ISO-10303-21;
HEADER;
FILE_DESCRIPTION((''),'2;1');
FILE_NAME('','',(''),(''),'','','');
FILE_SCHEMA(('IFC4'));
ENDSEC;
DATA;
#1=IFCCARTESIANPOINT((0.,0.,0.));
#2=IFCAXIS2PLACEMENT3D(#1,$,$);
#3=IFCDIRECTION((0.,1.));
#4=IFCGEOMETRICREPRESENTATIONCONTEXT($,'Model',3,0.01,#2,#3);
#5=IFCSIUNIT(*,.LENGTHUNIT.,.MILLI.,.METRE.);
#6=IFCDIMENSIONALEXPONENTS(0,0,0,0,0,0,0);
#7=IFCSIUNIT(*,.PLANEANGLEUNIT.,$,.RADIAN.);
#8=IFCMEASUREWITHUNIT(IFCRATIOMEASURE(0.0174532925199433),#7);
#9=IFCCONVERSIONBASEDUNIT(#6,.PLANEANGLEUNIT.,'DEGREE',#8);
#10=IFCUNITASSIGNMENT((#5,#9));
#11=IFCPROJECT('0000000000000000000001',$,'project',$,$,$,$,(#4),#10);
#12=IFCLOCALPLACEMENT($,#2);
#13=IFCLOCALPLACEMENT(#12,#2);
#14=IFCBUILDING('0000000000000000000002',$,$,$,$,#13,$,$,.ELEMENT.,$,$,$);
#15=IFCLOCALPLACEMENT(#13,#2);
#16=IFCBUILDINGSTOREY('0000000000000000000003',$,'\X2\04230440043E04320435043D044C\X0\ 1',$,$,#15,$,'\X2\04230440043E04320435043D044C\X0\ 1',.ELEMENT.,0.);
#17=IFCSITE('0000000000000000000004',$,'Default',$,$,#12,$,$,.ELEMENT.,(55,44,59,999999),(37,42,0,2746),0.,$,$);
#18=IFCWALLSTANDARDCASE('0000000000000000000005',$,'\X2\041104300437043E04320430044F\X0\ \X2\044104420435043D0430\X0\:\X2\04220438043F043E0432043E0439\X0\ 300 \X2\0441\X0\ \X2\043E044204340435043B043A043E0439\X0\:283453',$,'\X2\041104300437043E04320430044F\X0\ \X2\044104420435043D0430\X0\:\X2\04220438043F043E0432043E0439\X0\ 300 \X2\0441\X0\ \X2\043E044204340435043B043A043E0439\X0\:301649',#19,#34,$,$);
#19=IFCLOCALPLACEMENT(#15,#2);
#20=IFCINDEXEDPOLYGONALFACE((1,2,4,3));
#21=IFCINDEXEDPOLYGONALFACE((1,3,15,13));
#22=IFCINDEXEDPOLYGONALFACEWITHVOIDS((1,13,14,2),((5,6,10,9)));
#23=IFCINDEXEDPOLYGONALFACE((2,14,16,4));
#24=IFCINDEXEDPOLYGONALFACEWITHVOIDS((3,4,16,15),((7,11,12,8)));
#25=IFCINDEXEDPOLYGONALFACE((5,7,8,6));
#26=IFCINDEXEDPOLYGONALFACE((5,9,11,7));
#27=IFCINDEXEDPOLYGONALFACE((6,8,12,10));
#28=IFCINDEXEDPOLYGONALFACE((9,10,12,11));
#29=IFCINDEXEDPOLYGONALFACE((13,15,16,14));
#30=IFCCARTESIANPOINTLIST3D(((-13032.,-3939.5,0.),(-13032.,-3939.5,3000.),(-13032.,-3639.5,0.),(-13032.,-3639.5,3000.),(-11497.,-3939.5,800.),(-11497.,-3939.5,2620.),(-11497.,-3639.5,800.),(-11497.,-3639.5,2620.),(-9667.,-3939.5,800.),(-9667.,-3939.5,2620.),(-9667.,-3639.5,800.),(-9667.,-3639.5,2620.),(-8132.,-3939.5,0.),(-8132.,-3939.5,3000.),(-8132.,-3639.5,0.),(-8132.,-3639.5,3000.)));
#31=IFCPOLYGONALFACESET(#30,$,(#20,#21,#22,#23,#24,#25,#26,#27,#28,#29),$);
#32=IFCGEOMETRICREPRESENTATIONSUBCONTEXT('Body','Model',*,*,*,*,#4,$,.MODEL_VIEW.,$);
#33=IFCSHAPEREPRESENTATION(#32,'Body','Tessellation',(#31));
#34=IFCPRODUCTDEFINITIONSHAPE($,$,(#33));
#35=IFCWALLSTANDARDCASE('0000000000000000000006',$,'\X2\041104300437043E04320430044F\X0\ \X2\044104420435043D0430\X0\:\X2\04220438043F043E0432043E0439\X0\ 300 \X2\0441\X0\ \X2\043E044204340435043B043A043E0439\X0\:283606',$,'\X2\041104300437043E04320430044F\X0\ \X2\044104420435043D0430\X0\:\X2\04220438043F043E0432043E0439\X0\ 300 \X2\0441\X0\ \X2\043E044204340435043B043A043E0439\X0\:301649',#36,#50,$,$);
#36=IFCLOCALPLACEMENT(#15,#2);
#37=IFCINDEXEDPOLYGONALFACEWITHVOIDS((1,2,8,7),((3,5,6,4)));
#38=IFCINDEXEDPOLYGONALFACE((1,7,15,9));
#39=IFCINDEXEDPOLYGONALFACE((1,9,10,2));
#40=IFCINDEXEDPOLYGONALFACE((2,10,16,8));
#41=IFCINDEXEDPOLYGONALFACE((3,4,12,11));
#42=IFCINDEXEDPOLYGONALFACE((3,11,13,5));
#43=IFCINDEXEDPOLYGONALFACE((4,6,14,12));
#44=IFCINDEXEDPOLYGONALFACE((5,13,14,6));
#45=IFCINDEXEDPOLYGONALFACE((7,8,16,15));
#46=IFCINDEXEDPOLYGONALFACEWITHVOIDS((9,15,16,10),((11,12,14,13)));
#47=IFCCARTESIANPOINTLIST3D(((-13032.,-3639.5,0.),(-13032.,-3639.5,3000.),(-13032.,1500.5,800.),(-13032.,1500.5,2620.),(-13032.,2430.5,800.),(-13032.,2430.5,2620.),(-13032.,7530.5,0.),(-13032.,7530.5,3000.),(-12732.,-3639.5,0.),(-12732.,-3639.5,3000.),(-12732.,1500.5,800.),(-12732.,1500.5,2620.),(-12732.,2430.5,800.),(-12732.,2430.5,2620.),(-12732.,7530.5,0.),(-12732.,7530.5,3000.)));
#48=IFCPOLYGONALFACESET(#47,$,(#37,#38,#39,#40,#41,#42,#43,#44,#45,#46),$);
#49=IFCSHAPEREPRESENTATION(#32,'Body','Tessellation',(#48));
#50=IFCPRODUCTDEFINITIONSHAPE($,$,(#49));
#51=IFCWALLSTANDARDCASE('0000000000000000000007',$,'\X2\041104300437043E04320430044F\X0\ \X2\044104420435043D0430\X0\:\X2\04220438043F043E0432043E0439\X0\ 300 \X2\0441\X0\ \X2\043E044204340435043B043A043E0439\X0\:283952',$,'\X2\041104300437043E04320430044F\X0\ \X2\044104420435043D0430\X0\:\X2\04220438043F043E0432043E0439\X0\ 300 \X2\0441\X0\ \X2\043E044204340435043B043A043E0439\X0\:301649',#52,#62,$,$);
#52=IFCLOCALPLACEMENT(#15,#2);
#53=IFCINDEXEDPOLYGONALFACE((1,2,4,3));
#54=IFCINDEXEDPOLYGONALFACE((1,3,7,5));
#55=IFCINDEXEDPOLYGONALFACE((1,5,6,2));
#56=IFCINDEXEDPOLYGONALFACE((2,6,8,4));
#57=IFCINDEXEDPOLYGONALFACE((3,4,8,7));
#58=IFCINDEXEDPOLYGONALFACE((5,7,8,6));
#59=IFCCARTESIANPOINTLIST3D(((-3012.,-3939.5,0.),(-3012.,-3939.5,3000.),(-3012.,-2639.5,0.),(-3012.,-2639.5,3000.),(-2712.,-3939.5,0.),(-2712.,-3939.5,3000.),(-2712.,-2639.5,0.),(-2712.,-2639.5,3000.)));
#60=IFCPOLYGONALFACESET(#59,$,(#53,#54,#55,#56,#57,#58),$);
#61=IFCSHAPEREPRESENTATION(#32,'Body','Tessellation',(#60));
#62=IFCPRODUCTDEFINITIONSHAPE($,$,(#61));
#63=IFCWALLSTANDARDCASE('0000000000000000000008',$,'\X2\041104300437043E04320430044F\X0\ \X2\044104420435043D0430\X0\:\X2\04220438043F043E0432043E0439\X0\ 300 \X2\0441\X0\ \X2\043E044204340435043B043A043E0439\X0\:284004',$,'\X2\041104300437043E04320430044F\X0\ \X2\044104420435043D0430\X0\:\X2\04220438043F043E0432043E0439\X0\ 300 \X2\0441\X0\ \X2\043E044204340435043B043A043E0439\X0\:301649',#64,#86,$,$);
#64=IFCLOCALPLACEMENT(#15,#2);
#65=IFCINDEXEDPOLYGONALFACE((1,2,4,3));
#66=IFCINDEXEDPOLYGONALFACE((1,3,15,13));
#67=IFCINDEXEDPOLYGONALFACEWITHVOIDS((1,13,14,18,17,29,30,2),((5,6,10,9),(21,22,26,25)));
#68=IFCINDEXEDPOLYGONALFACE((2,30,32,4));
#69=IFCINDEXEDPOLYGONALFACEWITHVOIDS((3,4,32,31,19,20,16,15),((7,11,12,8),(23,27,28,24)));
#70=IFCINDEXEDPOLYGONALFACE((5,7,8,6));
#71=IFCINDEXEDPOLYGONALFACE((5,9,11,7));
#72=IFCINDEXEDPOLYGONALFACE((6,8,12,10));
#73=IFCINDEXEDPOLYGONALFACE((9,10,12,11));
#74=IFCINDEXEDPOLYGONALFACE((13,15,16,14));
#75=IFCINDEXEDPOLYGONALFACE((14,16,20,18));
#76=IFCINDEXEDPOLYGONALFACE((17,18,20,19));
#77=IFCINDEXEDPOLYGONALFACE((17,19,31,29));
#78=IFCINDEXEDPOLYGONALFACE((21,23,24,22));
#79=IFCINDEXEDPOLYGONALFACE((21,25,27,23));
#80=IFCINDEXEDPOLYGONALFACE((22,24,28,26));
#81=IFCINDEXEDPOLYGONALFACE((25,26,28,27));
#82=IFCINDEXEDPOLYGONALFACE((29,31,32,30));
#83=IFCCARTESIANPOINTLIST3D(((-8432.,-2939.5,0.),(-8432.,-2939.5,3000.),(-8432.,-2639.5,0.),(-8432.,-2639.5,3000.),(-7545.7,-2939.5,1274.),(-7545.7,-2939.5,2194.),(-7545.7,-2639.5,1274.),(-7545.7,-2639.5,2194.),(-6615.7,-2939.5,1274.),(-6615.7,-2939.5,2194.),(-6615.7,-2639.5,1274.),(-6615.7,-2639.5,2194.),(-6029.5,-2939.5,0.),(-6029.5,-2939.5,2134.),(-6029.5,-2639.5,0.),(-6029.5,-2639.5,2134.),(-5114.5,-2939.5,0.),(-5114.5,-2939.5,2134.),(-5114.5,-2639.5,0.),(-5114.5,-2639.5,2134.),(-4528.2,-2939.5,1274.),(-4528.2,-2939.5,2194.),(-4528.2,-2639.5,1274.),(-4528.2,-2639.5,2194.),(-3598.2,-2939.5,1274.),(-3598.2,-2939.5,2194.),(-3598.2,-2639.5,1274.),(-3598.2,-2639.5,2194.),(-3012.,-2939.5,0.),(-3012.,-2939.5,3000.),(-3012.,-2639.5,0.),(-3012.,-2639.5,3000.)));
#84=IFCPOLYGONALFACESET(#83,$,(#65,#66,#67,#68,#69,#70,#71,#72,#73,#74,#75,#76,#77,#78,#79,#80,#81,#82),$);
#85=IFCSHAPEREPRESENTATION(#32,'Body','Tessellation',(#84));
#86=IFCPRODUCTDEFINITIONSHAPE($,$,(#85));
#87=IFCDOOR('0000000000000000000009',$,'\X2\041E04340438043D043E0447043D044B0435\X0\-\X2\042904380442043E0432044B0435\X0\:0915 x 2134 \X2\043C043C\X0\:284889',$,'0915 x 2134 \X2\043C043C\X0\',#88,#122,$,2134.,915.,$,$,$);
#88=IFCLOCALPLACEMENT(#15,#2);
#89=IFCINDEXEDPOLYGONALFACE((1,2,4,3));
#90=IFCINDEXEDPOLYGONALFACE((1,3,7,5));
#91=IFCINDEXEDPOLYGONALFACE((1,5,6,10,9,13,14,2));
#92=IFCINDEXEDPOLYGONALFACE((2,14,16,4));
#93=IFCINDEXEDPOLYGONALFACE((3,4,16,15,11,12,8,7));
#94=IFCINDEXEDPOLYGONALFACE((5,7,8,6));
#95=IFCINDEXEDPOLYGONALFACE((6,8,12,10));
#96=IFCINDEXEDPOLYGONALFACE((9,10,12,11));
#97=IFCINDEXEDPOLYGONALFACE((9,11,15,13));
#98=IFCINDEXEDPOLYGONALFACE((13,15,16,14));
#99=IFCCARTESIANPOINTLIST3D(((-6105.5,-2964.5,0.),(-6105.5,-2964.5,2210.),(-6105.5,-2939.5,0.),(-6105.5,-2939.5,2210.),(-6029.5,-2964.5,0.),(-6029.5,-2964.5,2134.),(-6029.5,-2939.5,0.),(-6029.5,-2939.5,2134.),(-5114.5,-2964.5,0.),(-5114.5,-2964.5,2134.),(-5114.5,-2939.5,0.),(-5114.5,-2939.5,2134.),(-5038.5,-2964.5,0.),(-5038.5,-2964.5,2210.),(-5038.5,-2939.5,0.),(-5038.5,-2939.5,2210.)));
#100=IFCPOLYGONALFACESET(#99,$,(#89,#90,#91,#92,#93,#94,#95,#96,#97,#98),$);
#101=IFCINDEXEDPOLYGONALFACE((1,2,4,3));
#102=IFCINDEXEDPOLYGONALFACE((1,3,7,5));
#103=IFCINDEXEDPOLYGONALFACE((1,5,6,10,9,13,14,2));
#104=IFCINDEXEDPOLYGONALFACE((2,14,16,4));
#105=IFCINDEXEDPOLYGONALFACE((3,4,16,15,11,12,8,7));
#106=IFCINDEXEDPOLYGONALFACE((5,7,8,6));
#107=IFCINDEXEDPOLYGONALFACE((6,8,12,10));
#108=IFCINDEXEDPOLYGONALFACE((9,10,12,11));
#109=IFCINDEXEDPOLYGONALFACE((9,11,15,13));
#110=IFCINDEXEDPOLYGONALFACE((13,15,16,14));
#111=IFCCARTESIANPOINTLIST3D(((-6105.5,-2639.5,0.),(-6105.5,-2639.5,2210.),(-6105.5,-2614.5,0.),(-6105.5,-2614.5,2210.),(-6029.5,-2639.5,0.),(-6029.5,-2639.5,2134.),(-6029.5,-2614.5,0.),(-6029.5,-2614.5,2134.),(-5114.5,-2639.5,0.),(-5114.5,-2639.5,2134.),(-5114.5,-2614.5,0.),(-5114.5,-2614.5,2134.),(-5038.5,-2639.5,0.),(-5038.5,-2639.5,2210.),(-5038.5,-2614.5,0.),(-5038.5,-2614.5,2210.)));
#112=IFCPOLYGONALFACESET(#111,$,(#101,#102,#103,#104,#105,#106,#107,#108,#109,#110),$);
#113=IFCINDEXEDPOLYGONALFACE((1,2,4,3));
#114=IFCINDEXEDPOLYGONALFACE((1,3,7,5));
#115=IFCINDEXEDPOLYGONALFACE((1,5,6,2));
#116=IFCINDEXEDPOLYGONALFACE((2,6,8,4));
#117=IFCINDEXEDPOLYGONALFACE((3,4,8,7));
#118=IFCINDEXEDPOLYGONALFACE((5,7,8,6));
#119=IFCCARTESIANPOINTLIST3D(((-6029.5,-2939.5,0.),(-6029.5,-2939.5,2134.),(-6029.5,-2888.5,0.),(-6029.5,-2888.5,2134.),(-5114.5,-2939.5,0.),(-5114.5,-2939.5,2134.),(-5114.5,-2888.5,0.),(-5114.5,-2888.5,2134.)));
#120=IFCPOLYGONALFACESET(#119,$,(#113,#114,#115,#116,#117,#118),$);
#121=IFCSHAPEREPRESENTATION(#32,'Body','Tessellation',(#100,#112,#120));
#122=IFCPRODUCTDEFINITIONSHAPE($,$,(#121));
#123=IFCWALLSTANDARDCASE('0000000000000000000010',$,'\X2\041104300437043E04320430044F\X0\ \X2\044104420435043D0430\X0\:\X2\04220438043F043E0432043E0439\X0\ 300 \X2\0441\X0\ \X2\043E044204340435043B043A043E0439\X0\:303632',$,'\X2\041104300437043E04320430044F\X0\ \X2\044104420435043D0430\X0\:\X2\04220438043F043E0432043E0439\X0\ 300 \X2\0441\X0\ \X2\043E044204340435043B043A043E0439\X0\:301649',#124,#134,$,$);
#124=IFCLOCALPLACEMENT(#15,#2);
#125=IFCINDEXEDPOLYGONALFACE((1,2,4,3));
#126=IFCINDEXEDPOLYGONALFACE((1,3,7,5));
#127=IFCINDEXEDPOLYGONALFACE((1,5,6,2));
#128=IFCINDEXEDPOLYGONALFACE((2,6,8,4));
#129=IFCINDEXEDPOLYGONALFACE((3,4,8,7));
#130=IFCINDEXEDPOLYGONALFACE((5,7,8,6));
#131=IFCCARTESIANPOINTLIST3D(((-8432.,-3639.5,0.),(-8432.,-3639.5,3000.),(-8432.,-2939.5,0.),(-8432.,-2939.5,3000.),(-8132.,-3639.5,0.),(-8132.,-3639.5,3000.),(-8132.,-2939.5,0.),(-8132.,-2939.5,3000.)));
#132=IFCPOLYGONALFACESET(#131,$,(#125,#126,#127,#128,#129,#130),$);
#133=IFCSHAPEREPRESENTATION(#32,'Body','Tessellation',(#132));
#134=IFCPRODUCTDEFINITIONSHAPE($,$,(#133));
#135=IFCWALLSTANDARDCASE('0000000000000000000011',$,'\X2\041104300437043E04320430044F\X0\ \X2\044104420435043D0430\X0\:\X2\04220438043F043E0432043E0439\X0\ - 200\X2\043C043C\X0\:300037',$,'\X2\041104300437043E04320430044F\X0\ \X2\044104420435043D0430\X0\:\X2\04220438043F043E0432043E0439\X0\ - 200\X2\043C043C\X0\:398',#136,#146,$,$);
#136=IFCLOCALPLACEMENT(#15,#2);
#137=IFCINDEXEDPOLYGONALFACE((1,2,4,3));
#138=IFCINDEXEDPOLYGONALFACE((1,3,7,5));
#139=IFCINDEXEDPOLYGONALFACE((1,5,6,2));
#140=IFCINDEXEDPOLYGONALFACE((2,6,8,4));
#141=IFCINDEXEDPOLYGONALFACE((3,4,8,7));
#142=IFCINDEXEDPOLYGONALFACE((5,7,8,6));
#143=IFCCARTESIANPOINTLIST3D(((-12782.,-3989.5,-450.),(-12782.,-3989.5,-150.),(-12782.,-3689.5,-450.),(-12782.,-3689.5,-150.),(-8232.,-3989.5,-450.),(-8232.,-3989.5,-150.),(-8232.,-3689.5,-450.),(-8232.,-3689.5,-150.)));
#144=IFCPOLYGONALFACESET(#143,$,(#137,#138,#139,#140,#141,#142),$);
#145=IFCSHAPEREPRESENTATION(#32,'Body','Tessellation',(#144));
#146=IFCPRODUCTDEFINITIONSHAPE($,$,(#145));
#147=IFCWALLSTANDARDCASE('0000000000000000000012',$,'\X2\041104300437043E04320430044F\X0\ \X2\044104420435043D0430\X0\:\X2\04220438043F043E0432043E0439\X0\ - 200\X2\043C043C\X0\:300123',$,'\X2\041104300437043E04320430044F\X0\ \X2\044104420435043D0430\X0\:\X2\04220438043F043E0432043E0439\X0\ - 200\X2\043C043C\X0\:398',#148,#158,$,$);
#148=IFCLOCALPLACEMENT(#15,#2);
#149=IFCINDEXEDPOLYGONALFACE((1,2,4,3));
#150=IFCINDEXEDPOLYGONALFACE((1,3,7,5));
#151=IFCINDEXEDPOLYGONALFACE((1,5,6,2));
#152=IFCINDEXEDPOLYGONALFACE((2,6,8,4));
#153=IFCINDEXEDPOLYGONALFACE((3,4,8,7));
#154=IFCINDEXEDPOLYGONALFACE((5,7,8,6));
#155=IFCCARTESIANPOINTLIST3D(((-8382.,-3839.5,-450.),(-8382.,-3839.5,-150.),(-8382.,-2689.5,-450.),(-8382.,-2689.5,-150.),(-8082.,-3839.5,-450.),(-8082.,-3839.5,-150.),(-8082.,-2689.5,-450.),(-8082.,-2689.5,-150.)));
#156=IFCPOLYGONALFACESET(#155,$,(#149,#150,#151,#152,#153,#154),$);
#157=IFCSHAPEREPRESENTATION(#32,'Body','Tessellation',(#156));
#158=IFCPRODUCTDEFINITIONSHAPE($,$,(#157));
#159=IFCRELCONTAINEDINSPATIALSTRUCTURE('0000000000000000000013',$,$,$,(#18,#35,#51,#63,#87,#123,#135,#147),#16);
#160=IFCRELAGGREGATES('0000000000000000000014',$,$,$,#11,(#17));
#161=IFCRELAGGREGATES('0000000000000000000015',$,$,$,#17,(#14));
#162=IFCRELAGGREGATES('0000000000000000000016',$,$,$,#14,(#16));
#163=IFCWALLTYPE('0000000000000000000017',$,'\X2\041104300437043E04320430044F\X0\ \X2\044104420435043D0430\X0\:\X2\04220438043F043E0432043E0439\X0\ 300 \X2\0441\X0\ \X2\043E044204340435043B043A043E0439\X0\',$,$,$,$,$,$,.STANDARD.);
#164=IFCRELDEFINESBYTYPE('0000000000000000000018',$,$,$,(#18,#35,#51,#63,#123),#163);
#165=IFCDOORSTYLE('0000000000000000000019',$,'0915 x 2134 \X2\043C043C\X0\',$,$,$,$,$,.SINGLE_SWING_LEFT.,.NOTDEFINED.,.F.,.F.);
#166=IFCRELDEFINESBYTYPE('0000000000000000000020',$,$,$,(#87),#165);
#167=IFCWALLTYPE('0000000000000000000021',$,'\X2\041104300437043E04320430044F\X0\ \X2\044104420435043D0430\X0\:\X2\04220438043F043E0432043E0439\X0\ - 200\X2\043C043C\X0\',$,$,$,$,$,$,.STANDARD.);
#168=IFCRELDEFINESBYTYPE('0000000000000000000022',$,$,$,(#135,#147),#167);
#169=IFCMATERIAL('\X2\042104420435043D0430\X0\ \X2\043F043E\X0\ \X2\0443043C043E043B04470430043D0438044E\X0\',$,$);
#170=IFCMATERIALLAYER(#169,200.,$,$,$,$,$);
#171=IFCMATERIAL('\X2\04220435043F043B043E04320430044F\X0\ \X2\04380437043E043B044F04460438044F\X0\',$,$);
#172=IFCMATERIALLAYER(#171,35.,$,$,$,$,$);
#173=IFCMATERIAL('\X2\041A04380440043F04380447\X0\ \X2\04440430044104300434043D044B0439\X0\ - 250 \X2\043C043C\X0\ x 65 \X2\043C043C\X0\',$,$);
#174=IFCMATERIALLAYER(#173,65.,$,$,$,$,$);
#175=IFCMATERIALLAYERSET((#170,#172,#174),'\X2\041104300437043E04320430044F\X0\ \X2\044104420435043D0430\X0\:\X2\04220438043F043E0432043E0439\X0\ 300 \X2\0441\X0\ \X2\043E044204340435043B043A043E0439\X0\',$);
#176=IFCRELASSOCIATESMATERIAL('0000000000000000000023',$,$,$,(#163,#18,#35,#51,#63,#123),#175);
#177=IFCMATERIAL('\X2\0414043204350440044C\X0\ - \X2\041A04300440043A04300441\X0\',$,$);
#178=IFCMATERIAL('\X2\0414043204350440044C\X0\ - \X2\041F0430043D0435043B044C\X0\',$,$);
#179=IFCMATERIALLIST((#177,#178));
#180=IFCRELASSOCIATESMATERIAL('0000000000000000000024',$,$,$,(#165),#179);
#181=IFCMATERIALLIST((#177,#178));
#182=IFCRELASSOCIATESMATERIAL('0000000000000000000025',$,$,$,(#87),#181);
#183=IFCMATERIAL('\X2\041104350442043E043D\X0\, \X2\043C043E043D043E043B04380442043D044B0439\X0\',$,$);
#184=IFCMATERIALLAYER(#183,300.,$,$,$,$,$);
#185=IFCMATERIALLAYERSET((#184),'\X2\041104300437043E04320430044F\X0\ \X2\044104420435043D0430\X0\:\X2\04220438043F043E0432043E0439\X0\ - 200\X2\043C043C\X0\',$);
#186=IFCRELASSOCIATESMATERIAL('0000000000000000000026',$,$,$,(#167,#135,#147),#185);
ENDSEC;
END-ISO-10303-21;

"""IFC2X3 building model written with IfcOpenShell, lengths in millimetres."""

from ifc_helpers import new_model, entity, si_unit, converted_unit, direction, frame, frame_2d, origin, origin_2d_with_axis, place, context, subcontext, project, spatial, polyline, rectangle, outline, extrude, clip, halfspace, source, transform, mapped, material, material_list, layer, layer_set, layer_usage, type_object, type_shapes, element, fill, save


model = new_model("IFC2X3")

# Units and contexts
model_context = context("Model", 3, precision=0.01, world=origin(), true_north=direction((0.0, 1.0)))
body_context = subcontext(model_context, "Body", "Model", "MODEL_VIEW")
ifc_project = project(units=[si_unit("LENGTHUNIT", "METRE", prefix="MILLI"), converted_unit("PLANEANGLEUNIT", "DEGREE", entity("IfcRatioMeasure", 0.0174532925199433), si_unit("PLANEANGLEUNIT", "RADIAN"), dimensions=[0, 0, 0, 0, 0, 0, 0])], contexts=[model_context])

# Site, building, storey
site_placement = place(None, origin())
site = spatial("IfcSite", under=ifc_project, at=site_placement, Name="Default", CompositionType="ELEMENT", RefLatitude=(55, 44, 59, 999999), RefLongitude=(37, 42, 0, 2746), RefElevation=0.0)
building_placement = place(site_placement, origin())
building = spatial("IfcBuilding", under=site, at=building_placement, CompositionType="ELEMENT")
storey_placement = place(building_placement, origin())
storey = spatial("IfcBuildingStorey", under=building, at=storey_placement, Name="Уровень 1", LongName="Уровень 1", CompositionType="ELEMENT", Elevation=0.0)

# Walls, openings
ifc_material_1 = material(Name="Стена по умолчанию")
ifc_layer_1 = layer(ifc_material_1, 200.0)
ifc_material_2 = material(Name="Тепловая изоляция")
ifc_layer_2 = layer(ifc_material_2, 35.0)
ifc_material_3 = material(Name="Кирпич фасадный - 250 мм x 65 мм")
ifc_layer_3 = layer(ifc_material_3, 65.0)
ifc_layer_set_1 = layer_set([ifc_layer_1, ifc_layer_2, ifc_layer_3], Name="Базовая стена:Типовой 300 с отделкой")
ifc_layer_usage_1 = layer_usage(ifc_layer_set_1, "AXIS2", "NEGATIVE", 150.0)
wall_type_1 = type_object("IfcWallType", Name="Базовая стена:Типовой 300 с отделкой", PredefinedType="STANDARD", material=ifc_layer_set_1)
wall_1_placement = place(storey_placement, frame((-13032.0, -3789.5, 0.0)))
wall_1 = element("IfcWallStandardCase", 1, at=wall_1_placement, inside=storey, type_object=wall_type_1, material=ifc_layer_usage_1, Name="Базовая стена:Типовой 300 с отделкой:283453", ObjectType="Базовая стена:Типовой 300 с отделкой:301649", context=body_context, shape_type="Clipping", body=[
    clip(extrude(rectangle(XDim=4900.0, YDim=300.0, at=frame_2d((2450.0, 0.0), x_axis=(-1.0, 0.0))), origin(), (0.0, 0.0, 1.0), 3000.0), halfspace(origin(), True)),
])
opening_1_placement = place(wall_1_placement, frame((3365.0, 150.0, 800.0)))
element("IfcOpeningElement", 2, at=opening_1_placement, cuts=wall_1, ObjectType="Opening", context=body_context, shape_type="SweptSolid", body=[
    extrude(rectangle(XDim=1820.0, YDim=1830.0, at=frame_2d((910.0, 915.0), x_axis=(1.0, 0.0))), frame((0.0, 0.0, 0.0), z_axis=(0.0, -1.0, 0.0), x_axis=(0.0, 0.0, 1.0)), (0.0, 0.0, 1.0), 300.0),
])
ifc_layer_usage_2 = layer_usage(ifc_layer_set_1, "AXIS2", "NEGATIVE", 150.0)
wall_2_placement = place(storey_placement, frame((-12882.0, 7530.5, 0.0), z_axis=(0.0, 0.0, 1.0), x_axis=(0.0, -1.0, 0.0)))
wall_2 = element("IfcWallStandardCase", 3, at=wall_2_placement, inside=storey, type_object=wall_type_1, material=ifc_layer_usage_2, Name="Базовая стена:Типовой 300 с отделкой:283606", ObjectType="Базовая стена:Типовой 300 с отделкой:301649", context=body_context, shape_type="Clipping", body=[
    clip(extrude(rectangle(XDim=11170.0, YDim=300.0, at=frame_2d((5585.0, 0.0), x_axis=(-1.0, 0.0))), origin(), (0.0, 0.0, 1.0), 3000.0), halfspace(origin(), True)),
])
opening_2_placement = place(wall_2_placement, frame((6030.0, 150.0, 800.0)))
element("IfcOpeningElement", 4, at=opening_2_placement, cuts=wall_2, ObjectType="Opening", context=body_context, shape_type="SweptSolid", body=[
    extrude(rectangle(XDim=1820.0, YDim=930.0, at=frame_2d((910.0, 465.0), x_axis=(1.0, 0.0))), frame((0.0, 0.0, 0.0), z_axis=(0.0, -1.0, 0.0), x_axis=(0.0, 0.0, 1.0)), (0.0, 0.0, 1.0), 300.0),
])

# Wall
ifc_layer_usage_3 = layer_usage(ifc_layer_set_1, "AXIS2", "NEGATIVE", 150.0)
wall_3_placement = place(storey_placement, frame((-2862.0, -2639.5, 0.0), z_axis=(0.0, 0.0, 1.0), x_axis=(0.0, -1.0, 0.0)))
element("IfcWallStandardCase", 5, at=wall_3_placement, inside=storey, type_object=wall_type_1, material=ifc_layer_usage_3, Name="Базовая стена:Типовой 300 с отделкой:283952", ObjectType="Базовая стена:Типовой 300 с отделкой:301649", context=body_context, shape_type="Clipping", body=[
    clip(extrude(rectangle(XDim=1300.0, YDim=300.0, at=frame_2d((650.0, 0.0), x_axis=(-1.0, 0.0))), origin(), (0.0, 0.0, 1.0), 3000.0), halfspace(origin(), True)),
])

# Wall, openings, door
ifc_layer_usage_4 = layer_usage(ifc_layer_set_1, "AXIS2", "NEGATIVE", 150.0)
wall_4_placement = place(storey_placement, frame((-8432.0, -2789.5, 0.0)))
wall_4 = element("IfcWallStandardCase", 6, at=wall_4_placement, inside=storey, type_object=wall_type_1, material=ifc_layer_usage_4, Name="Базовая стена:Типовой 300 с отделкой:284004", ObjectType="Базовая стена:Типовой 300 с отделкой:301649", context=body_context, shape_type="Clipping", body=[
    clip(extrude(rectangle(XDim=5420.0, YDim=300.0, at=frame_2d((2710.0, 0.0), x_axis=(-1.0, 0.0))), origin(), (0.0, 0.0, 1.0), 3000.0), halfspace(origin(), True)),
])
opening_3_placement = place(wall_4_placement, frame((3317.5, 150.0, 0.0)))
opening_3 = element("IfcOpeningElement", 7, at=opening_3_placement, cuts=wall_4, ObjectType="Opening", context=body_context, shape_type="SweptSolid", body=[
    extrude(rectangle(XDim=915.0, YDim=2134.0, at=frame_2d((1067.0, 457.5), x_axis=(0.0, -1.0))), frame((0.0, 0.0, 0.0), z_axis=(0.0, -1.0, 0.0), x_axis=(0.0, 0.0, 1.0)), (0.0, 0.0, 1.0), 300.0),
])
opening_4_placement = place(wall_4_placement, frame((4833.8, 150.0, 1274.0)))
element("IfcOpeningElement", 8, at=opening_4_placement, cuts=wall_4, ObjectType="Opening", context=body_context, shape_type="SweptSolid", body=[
    extrude(rectangle(XDim=920.0, YDim=930.0, at=frame_2d((460.0, 465.0), x_axis=(1.0, 0.0))), frame((0.0, 0.0, 0.0), z_axis=(0.0, -1.0, 0.0), x_axis=(0.0, 0.0, 1.0)), (0.0, 0.0, 1.0), 300.0),
])
opening_5_placement = place(wall_4_placement, frame((1816.2, 150.0, 1274.0)))
element("IfcOpeningElement", 9, at=opening_5_placement, cuts=wall_4, ObjectType="Opening", context=body_context, shape_type="SweptSolid", body=[
    extrude(rectangle(XDim=920.0, YDim=930.0, at=frame_2d((460.0, 465.0), x_axis=(1.0, 0.0))), frame((0.0, 0.0, 0.0), z_axis=(0.0, -1.0, 0.0), x_axis=(0.0, 0.0, 1.0)), (0.0, 0.0, 1.0), 300.0),
])
ifc_material_4 = material(Name="Дверь - Каркас")
ifc_material_5 = material(Name="Дверь - Панель")
ifc_material_list_1 = material_list([ifc_material_4, ifc_material_5])
ifc_material_list_2 = material_list([ifc_material_4, ifc_material_5])
door_style = type_object("IfcDoorStyle", Name="0915 x 2134 мм", ConstructionType="NOTDEFINED", OperationType="SINGLE_SWING_LEFT", ParameterTakesPrecedence=False, Sizeable=False, material=ifc_material_list_2)
shared_shape = source(origin(), body_context, "Body", "SweptSolid", [
    extrude(outline(polyline([(-533.5, -1124.0), (533.5, -1124.0), (533.5, 1086.0), (457.5, 1086.0), (457.5, -1048.0), (-457.5, -1048.0), (-457.5, 1086.0), (-533.5, 1086.0), (-533.5, -1124.0)])), frame((457.5, 325.0, 1086.0), z_axis=(0.0, -1.0, 0.0), x_axis=(-1.0, 0.0, 0.0)), (0.0, 0.0, 1.0), 25.0),
    extrude(outline(polyline([(-1124.0, -533.5), (1086.0, -533.5), (1086.0, -457.5), (-1048.0, -457.5), (-1048.0, 457.5), (1086.0, 457.5), (1086.0, 533.5), (-1124.0, 533.5), (-1124.0, -533.5)])), frame((457.5, 0.0, 1086.0), z_axis=(0.0, -1.0, 0.0), x_axis=(0.0, 0.0, -1.0)), (0.0, 0.0, 1.0), 25.0),
    extrude(rectangle(XDim=915.0, YDim=51.0, at=origin_2d_with_axis()), frame((457.5, 274.5, 0.0)), (0.0, 0.0, 1.0), 2134.0),
])
type_shapes(door_style, [shared_shape])
door_placement = place(opening_3_placement, frame((0.0, 0.0, 0.0), z_axis=(0.0, 0.0, 1.0), x_axis=(-1.0, 0.0, 0.0)))
door = element("IfcDoor", 10, at=door_placement, inside=storey, type_object=door_style, material=ifc_material_list_1, Name="Одиночные-Щитовые:0915 x 2134 мм:284889", ObjectType="0915 x 2134 мм", OverallHeight=2134.0, OverallWidth=915.0, context=body_context, shape_type="MappedRepresentation", body=[
    mapped(shared_shape, transform((0.0, 0.0, 0.0), scale=1.0)),
])
fill(opening_3, door)

# Walls
ifc_layer_usage_5 = layer_usage(ifc_layer_set_1, "AXIS2", "NEGATIVE", 150.0)
wall_5_placement = place(storey_placement, frame((-8282.0, -3639.5, 0.0), z_axis=(0.0, 0.0, 1.0), x_axis=(0.0, 1.0, 0.0)))
element("IfcWallStandardCase", 11, at=wall_5_placement, inside=storey, type_object=wall_type_1, material=ifc_layer_usage_5, Name="Базовая стена:Типовой 300 с отделкой:303632", ObjectType="Базовая стена:Типовой 300 с отделкой:301649", context=body_context, shape_type="Clipping", body=[
    clip(extrude(rectangle(XDim=700.0, YDim=300.0, at=frame_2d((350.0, 0.0), x_axis=(-1.0, 0.0))), origin(), (0.0, 0.0, 1.0), 3000.0), halfspace(origin(), True)),
])
ifc_material_6 = material(Name="Бетон, монолитный")
ifc_layer_4 = layer(ifc_material_6, 300.0)
ifc_layer_set_2 = layer_set([ifc_layer_4], Name="Базовая стена:Типовой - 200мм")
wall_type_2 = type_object("IfcWallType", Name="Базовая стена:Типовой - 200мм", PredefinedType="STANDARD", material=ifc_layer_set_2)
ifc_layer_usage_6 = layer_usage(ifc_layer_set_2, "AXIS2", "NEGATIVE", 150.0)
wall_6_placement = place(storey_placement, frame((-12782.0, -3839.5, -450.0)))
element("IfcWallStandardCase", 12, at=wall_6_placement, inside=storey, type_object=wall_type_2, material=ifc_layer_usage_6, Name="Базовая стена:Типовой - 200мм:300037", ObjectType="Базовая стена:Типовой - 200мм:398", context=body_context, shape_type="SweptSolid", body=[
    extrude(rectangle(XDim=4550.0, YDim=300.0, at=frame_2d((2275.0, 0.0), x_axis=(-1.0, 0.0))), origin(), (0.0, 0.0, 1.0), 300.0),
])
ifc_layer_usage_7 = layer_usage(ifc_layer_set_2, "AXIS2", "NEGATIVE", 150.0)
wall_7_placement = place(storey_placement, frame((-8232.0, -3839.5, -450.0), z_axis=(0.0, 0.0, 1.0), x_axis=(0.0, 1.0, 0.0)))
element("IfcWallStandardCase", 13, at=wall_7_placement, inside=storey, type_object=wall_type_2, material=ifc_layer_usage_7, Name="Базовая стена:Типовой - 200мм:300123", ObjectType="Базовая стена:Типовой - 200мм:398", context=body_context, shape_type="SweptSolid", body=[
    extrude(rectangle(XDim=1150.0, YDim=300.0, at=frame_2d((575.0, 0.0), x_axis=(-1.0, 0.0))), origin(), (0.0, 0.0, 1.0), 300.0),
])

save(model, "model.ifc")
